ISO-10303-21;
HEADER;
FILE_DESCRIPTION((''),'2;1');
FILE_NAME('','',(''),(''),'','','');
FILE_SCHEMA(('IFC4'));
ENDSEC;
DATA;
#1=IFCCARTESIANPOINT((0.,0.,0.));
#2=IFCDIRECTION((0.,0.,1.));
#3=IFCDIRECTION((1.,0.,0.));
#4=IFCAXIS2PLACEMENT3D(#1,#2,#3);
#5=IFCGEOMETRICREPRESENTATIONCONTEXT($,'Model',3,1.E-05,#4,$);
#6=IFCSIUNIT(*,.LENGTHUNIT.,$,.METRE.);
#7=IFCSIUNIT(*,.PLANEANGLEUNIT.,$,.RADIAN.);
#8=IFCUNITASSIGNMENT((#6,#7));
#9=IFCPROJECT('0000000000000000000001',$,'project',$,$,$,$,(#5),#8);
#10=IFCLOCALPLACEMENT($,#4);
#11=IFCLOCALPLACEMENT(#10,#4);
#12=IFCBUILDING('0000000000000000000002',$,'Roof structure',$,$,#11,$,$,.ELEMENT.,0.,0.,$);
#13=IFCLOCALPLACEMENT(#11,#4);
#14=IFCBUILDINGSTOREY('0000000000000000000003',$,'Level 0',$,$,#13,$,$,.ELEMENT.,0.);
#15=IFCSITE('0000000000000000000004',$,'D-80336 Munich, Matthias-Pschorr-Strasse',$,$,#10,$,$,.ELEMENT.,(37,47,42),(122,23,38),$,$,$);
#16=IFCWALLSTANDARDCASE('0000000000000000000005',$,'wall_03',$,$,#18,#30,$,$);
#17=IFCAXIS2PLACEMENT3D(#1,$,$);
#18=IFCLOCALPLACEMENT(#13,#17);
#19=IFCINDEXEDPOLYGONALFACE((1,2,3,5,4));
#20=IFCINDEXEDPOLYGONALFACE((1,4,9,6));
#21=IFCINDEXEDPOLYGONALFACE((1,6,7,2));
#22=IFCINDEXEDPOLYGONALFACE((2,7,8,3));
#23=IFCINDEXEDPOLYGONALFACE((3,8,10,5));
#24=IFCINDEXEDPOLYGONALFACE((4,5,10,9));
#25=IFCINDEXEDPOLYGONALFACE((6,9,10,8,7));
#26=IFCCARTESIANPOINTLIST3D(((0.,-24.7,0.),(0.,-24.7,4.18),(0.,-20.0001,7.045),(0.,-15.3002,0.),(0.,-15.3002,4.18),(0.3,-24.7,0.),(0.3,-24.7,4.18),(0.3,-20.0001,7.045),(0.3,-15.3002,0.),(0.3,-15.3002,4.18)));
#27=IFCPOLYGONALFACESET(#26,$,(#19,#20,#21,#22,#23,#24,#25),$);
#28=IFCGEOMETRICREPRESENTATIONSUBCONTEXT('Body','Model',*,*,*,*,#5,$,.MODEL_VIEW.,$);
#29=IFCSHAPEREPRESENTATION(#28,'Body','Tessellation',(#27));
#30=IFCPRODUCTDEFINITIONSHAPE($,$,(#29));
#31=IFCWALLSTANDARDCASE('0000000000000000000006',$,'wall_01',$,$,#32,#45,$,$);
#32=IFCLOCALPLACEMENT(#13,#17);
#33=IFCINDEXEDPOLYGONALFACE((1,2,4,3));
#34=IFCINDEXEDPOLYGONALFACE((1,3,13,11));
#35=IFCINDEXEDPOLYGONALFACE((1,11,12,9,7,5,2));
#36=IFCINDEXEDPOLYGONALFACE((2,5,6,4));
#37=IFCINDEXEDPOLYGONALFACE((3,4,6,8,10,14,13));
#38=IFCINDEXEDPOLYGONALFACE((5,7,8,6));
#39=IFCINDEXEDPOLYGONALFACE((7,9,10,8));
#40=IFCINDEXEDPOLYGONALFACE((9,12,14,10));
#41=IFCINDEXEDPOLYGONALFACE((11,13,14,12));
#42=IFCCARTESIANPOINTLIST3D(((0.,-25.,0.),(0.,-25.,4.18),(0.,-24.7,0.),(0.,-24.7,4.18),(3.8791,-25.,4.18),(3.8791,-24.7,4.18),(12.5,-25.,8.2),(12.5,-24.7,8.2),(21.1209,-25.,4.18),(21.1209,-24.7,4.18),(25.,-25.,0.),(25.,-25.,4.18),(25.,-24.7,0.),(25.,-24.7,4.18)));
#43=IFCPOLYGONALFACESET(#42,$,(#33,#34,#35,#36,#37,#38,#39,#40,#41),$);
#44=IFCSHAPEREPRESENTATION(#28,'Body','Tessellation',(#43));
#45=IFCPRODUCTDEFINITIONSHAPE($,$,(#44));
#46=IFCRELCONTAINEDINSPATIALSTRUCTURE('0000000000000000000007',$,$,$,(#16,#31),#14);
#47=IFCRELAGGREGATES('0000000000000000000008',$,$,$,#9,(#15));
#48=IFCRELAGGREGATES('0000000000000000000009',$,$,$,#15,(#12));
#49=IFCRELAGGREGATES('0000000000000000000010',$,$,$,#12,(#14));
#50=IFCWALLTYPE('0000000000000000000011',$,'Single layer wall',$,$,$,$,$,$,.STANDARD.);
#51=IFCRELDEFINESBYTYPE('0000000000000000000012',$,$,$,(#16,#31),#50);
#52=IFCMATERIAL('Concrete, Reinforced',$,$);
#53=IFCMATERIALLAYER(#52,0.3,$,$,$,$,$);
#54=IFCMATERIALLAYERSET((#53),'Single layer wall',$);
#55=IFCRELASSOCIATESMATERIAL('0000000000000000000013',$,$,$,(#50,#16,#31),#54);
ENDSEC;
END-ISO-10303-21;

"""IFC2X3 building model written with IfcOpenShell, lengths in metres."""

from ifc_helpers import new_model, si_unit, frame, origin_with_axes, place, context, subcontext, project, spatial, polyline, outline, extrude, clip, bounded_halfspace, material, layer, layer_set, layer_usage, type_object, element, save


model = new_model("IFC2X3")

# Units and contexts
model_context = context("Model", 3, precision=1e-05, world=origin_with_axes())
body_context = subcontext(model_context, "Body", "Model", "MODEL_VIEW")
ifc_project = project(units=[si_unit("LENGTHUNIT", "METRE"), si_unit("PLANEANGLEUNIT", "RADIAN")], contexts=[model_context])

# Site, building, storey
site_placement = place(None, origin_with_axes())
site = spatial("IfcSite", under=ifc_project, at=site_placement, Name="D-80336 Munich, Matthias-Pschorr-Strasse", CompositionType="ELEMENT", RefLatitude=(37, 47, 42), RefLongitude=(122, 23, 38))
building_placement = place(site_placement, origin_with_axes())
building = spatial("IfcBuilding", under=site, at=building_placement, Name="Roof structure", CompositionType="ELEMENT", ElevationOfRefHeight=0.0, ElevationOfTerrain=0.0)
storey_placement = place(building_placement, origin_with_axes())
storey = spatial("IfcBuildingStorey", under=building, at=storey_placement, Name="Level 0", CompositionType="ELEMENT", Elevation=0.0)

# Walls
ifc_material_1 = material(Name="Concrete, Reinforced")
ifc_layer_1 = layer(ifc_material_1, 0.3)
ifc_layer_set_1 = layer_set([ifc_layer_1], Name="Single layer wall")
wall_type = type_object("IfcWallType", Name="Single layer wall", PredefinedType="STANDARD", material=ifc_layer_set_1)
ifc_layer_usage_1 = layer_usage(ifc_layer_set_1, "AXIS2", "POSITIVE", 0.0)
wall_1_placement = place(storey_placement, frame((0.0, -15.3002, 0.0), z_axis=(0.0, 0.0, 1.0), x_axis=(0.0, -1.0, 0.0)))
element("IfcWallStandardCase", 1, at=wall_1_placement, inside=storey, type_object=wall_type, material=ifc_layer_usage_1, Name="wall_03", context=body_context, shape_type="Clipping", body=[
    clip(clip(extrude(outline(polyline([(4.6999, -0.15), (-4.6999, -0.15), (-4.6999, 0.15), (4.6999, 0.15), (4.6999, -0.15)])), frame((4.6999, 0.15, 0.0), z_axis=(0.0, 0.0, 1.0), x_axis=(1.0, 0.0, 0.0)), (0.0, 0.0, 1.0), 7.045), bounded_halfspace(frame((-13.0128, 0.0, -3.7524), z_axis=(-0.520502, 0.0, 0.853861), x_axis=(0.0, -1.0, 0.0)), False, frame((4.6999, 0.15, 0.0), z_axis=(0.0, 0.0, 1.0), x_axis=(1.0, 0.0, 0.0)), polyline([(-4.6999, -0.15), (0.0, -0.15), (0.0, 0.15), (-4.6999, 0.15), (-4.6999, -0.15)]))), bounded_halfspace(frame((-6.7507, 0.0, 14.0251), z_axis=(0.520502, 0.0, 0.853861), x_axis=(0.0, 1.0, 0.0)), False, frame((4.6999, 0.15, 0.0), z_axis=(0.0, 0.0, 1.0), x_axis=(1.0, 0.0, 0.0)), polyline([(0.0, -0.15), (4.6999, -0.15), (4.6999, 0.15), (0.0, 0.15), (0.0, -0.15)]))),
])
ifc_layer_usage_2 = layer_usage(ifc_layer_set_1, "AXIS2", "POSITIVE", 0.0)
wall_2_placement = place(storey_placement, frame((25.0, -24.7, 0.0), z_axis=(0.0, 0.0, 1.0), x_axis=(-1.0, 0.0, 0.0)))
element("IfcWallStandardCase", 2, at=wall_2_placement, inside=storey, type_object=wall_type, material=ifc_layer_usage_2, Name="wall_01", context=body_context, shape_type="Clipping", body=[
    clip(clip(clip(clip(extrude(outline(polyline([(-12.5, 0.15), (12.5, 0.15), (12.5, -0.15), (-12.5, -0.15), (-12.5, 0.15)])), frame((12.5, 0.15, 0.0), z_axis=(0.0, 0.0, 1.0), x_axis=(1.0, 0.0, 0.0)), (0.0, 0.0, 1.0), 8.2), bounded_halfspace(frame((25.0, -24.7, 4.18), z_axis=(0.0, 0.0, 1.0), x_axis=(-1.0, 0.0, 0.0)), False, frame((12.5, 0.15, 0.0), z_axis=(0.0, 0.0, 1.0), x_axis=(1.0, 0.0, 0.0)), polyline([(-12.5, -0.15), (-8.6209, -0.15), (-8.6209, 0.15), (-12.5, 0.15), (-12.5, -0.15)]))), bounded_halfspace(frame((19.6266, -24.7, 11.5232), z_axis=(-0.422618, 0.0, 0.906308), x_axis=(0.0, -1.0, 0.0)), False, frame((12.5, 0.15, 0.0), z_axis=(0.0, 0.0, 1.0), x_axis=(1.0, 0.0, 0.0)), polyline([(-8.6209, -0.15), (0.0, -0.15), (0.0, 0.15), (-8.6209, 0.15), (-8.6209, -0.15)]))), bounded_halfspace(frame((25.9082, -24.7, 1.9477), z_axis=(0.422618, 0.0, 0.906308), x_axis=(0.0, 1.0, 0.0)), False, frame((12.5, 0.15, 0.0), z_axis=(0.0, 0.0, 1.0), x_axis=(1.0, 0.0, 0.0)), polyline([(0.0, -0.15), (8.6209, -0.15), (8.6209, 0.15), (0.0, 0.15), (0.0, -0.15)]))), bounded_halfspace(frame((25.0, -24.7, 4.18), z_axis=(0.0, 0.0, 1.0), x_axis=(-1.0, 0.0, 0.0)), False, frame((12.5, 0.15, 0.0), z_axis=(0.0, 0.0, 1.0), x_axis=(1.0, 0.0, 0.0)), polyline([(8.6209, -0.15), (12.5, -0.15), (12.5, 0.15), (8.6209, 0.15), (8.6209, -0.15)]))),
])

save(model, "model.ifc")
